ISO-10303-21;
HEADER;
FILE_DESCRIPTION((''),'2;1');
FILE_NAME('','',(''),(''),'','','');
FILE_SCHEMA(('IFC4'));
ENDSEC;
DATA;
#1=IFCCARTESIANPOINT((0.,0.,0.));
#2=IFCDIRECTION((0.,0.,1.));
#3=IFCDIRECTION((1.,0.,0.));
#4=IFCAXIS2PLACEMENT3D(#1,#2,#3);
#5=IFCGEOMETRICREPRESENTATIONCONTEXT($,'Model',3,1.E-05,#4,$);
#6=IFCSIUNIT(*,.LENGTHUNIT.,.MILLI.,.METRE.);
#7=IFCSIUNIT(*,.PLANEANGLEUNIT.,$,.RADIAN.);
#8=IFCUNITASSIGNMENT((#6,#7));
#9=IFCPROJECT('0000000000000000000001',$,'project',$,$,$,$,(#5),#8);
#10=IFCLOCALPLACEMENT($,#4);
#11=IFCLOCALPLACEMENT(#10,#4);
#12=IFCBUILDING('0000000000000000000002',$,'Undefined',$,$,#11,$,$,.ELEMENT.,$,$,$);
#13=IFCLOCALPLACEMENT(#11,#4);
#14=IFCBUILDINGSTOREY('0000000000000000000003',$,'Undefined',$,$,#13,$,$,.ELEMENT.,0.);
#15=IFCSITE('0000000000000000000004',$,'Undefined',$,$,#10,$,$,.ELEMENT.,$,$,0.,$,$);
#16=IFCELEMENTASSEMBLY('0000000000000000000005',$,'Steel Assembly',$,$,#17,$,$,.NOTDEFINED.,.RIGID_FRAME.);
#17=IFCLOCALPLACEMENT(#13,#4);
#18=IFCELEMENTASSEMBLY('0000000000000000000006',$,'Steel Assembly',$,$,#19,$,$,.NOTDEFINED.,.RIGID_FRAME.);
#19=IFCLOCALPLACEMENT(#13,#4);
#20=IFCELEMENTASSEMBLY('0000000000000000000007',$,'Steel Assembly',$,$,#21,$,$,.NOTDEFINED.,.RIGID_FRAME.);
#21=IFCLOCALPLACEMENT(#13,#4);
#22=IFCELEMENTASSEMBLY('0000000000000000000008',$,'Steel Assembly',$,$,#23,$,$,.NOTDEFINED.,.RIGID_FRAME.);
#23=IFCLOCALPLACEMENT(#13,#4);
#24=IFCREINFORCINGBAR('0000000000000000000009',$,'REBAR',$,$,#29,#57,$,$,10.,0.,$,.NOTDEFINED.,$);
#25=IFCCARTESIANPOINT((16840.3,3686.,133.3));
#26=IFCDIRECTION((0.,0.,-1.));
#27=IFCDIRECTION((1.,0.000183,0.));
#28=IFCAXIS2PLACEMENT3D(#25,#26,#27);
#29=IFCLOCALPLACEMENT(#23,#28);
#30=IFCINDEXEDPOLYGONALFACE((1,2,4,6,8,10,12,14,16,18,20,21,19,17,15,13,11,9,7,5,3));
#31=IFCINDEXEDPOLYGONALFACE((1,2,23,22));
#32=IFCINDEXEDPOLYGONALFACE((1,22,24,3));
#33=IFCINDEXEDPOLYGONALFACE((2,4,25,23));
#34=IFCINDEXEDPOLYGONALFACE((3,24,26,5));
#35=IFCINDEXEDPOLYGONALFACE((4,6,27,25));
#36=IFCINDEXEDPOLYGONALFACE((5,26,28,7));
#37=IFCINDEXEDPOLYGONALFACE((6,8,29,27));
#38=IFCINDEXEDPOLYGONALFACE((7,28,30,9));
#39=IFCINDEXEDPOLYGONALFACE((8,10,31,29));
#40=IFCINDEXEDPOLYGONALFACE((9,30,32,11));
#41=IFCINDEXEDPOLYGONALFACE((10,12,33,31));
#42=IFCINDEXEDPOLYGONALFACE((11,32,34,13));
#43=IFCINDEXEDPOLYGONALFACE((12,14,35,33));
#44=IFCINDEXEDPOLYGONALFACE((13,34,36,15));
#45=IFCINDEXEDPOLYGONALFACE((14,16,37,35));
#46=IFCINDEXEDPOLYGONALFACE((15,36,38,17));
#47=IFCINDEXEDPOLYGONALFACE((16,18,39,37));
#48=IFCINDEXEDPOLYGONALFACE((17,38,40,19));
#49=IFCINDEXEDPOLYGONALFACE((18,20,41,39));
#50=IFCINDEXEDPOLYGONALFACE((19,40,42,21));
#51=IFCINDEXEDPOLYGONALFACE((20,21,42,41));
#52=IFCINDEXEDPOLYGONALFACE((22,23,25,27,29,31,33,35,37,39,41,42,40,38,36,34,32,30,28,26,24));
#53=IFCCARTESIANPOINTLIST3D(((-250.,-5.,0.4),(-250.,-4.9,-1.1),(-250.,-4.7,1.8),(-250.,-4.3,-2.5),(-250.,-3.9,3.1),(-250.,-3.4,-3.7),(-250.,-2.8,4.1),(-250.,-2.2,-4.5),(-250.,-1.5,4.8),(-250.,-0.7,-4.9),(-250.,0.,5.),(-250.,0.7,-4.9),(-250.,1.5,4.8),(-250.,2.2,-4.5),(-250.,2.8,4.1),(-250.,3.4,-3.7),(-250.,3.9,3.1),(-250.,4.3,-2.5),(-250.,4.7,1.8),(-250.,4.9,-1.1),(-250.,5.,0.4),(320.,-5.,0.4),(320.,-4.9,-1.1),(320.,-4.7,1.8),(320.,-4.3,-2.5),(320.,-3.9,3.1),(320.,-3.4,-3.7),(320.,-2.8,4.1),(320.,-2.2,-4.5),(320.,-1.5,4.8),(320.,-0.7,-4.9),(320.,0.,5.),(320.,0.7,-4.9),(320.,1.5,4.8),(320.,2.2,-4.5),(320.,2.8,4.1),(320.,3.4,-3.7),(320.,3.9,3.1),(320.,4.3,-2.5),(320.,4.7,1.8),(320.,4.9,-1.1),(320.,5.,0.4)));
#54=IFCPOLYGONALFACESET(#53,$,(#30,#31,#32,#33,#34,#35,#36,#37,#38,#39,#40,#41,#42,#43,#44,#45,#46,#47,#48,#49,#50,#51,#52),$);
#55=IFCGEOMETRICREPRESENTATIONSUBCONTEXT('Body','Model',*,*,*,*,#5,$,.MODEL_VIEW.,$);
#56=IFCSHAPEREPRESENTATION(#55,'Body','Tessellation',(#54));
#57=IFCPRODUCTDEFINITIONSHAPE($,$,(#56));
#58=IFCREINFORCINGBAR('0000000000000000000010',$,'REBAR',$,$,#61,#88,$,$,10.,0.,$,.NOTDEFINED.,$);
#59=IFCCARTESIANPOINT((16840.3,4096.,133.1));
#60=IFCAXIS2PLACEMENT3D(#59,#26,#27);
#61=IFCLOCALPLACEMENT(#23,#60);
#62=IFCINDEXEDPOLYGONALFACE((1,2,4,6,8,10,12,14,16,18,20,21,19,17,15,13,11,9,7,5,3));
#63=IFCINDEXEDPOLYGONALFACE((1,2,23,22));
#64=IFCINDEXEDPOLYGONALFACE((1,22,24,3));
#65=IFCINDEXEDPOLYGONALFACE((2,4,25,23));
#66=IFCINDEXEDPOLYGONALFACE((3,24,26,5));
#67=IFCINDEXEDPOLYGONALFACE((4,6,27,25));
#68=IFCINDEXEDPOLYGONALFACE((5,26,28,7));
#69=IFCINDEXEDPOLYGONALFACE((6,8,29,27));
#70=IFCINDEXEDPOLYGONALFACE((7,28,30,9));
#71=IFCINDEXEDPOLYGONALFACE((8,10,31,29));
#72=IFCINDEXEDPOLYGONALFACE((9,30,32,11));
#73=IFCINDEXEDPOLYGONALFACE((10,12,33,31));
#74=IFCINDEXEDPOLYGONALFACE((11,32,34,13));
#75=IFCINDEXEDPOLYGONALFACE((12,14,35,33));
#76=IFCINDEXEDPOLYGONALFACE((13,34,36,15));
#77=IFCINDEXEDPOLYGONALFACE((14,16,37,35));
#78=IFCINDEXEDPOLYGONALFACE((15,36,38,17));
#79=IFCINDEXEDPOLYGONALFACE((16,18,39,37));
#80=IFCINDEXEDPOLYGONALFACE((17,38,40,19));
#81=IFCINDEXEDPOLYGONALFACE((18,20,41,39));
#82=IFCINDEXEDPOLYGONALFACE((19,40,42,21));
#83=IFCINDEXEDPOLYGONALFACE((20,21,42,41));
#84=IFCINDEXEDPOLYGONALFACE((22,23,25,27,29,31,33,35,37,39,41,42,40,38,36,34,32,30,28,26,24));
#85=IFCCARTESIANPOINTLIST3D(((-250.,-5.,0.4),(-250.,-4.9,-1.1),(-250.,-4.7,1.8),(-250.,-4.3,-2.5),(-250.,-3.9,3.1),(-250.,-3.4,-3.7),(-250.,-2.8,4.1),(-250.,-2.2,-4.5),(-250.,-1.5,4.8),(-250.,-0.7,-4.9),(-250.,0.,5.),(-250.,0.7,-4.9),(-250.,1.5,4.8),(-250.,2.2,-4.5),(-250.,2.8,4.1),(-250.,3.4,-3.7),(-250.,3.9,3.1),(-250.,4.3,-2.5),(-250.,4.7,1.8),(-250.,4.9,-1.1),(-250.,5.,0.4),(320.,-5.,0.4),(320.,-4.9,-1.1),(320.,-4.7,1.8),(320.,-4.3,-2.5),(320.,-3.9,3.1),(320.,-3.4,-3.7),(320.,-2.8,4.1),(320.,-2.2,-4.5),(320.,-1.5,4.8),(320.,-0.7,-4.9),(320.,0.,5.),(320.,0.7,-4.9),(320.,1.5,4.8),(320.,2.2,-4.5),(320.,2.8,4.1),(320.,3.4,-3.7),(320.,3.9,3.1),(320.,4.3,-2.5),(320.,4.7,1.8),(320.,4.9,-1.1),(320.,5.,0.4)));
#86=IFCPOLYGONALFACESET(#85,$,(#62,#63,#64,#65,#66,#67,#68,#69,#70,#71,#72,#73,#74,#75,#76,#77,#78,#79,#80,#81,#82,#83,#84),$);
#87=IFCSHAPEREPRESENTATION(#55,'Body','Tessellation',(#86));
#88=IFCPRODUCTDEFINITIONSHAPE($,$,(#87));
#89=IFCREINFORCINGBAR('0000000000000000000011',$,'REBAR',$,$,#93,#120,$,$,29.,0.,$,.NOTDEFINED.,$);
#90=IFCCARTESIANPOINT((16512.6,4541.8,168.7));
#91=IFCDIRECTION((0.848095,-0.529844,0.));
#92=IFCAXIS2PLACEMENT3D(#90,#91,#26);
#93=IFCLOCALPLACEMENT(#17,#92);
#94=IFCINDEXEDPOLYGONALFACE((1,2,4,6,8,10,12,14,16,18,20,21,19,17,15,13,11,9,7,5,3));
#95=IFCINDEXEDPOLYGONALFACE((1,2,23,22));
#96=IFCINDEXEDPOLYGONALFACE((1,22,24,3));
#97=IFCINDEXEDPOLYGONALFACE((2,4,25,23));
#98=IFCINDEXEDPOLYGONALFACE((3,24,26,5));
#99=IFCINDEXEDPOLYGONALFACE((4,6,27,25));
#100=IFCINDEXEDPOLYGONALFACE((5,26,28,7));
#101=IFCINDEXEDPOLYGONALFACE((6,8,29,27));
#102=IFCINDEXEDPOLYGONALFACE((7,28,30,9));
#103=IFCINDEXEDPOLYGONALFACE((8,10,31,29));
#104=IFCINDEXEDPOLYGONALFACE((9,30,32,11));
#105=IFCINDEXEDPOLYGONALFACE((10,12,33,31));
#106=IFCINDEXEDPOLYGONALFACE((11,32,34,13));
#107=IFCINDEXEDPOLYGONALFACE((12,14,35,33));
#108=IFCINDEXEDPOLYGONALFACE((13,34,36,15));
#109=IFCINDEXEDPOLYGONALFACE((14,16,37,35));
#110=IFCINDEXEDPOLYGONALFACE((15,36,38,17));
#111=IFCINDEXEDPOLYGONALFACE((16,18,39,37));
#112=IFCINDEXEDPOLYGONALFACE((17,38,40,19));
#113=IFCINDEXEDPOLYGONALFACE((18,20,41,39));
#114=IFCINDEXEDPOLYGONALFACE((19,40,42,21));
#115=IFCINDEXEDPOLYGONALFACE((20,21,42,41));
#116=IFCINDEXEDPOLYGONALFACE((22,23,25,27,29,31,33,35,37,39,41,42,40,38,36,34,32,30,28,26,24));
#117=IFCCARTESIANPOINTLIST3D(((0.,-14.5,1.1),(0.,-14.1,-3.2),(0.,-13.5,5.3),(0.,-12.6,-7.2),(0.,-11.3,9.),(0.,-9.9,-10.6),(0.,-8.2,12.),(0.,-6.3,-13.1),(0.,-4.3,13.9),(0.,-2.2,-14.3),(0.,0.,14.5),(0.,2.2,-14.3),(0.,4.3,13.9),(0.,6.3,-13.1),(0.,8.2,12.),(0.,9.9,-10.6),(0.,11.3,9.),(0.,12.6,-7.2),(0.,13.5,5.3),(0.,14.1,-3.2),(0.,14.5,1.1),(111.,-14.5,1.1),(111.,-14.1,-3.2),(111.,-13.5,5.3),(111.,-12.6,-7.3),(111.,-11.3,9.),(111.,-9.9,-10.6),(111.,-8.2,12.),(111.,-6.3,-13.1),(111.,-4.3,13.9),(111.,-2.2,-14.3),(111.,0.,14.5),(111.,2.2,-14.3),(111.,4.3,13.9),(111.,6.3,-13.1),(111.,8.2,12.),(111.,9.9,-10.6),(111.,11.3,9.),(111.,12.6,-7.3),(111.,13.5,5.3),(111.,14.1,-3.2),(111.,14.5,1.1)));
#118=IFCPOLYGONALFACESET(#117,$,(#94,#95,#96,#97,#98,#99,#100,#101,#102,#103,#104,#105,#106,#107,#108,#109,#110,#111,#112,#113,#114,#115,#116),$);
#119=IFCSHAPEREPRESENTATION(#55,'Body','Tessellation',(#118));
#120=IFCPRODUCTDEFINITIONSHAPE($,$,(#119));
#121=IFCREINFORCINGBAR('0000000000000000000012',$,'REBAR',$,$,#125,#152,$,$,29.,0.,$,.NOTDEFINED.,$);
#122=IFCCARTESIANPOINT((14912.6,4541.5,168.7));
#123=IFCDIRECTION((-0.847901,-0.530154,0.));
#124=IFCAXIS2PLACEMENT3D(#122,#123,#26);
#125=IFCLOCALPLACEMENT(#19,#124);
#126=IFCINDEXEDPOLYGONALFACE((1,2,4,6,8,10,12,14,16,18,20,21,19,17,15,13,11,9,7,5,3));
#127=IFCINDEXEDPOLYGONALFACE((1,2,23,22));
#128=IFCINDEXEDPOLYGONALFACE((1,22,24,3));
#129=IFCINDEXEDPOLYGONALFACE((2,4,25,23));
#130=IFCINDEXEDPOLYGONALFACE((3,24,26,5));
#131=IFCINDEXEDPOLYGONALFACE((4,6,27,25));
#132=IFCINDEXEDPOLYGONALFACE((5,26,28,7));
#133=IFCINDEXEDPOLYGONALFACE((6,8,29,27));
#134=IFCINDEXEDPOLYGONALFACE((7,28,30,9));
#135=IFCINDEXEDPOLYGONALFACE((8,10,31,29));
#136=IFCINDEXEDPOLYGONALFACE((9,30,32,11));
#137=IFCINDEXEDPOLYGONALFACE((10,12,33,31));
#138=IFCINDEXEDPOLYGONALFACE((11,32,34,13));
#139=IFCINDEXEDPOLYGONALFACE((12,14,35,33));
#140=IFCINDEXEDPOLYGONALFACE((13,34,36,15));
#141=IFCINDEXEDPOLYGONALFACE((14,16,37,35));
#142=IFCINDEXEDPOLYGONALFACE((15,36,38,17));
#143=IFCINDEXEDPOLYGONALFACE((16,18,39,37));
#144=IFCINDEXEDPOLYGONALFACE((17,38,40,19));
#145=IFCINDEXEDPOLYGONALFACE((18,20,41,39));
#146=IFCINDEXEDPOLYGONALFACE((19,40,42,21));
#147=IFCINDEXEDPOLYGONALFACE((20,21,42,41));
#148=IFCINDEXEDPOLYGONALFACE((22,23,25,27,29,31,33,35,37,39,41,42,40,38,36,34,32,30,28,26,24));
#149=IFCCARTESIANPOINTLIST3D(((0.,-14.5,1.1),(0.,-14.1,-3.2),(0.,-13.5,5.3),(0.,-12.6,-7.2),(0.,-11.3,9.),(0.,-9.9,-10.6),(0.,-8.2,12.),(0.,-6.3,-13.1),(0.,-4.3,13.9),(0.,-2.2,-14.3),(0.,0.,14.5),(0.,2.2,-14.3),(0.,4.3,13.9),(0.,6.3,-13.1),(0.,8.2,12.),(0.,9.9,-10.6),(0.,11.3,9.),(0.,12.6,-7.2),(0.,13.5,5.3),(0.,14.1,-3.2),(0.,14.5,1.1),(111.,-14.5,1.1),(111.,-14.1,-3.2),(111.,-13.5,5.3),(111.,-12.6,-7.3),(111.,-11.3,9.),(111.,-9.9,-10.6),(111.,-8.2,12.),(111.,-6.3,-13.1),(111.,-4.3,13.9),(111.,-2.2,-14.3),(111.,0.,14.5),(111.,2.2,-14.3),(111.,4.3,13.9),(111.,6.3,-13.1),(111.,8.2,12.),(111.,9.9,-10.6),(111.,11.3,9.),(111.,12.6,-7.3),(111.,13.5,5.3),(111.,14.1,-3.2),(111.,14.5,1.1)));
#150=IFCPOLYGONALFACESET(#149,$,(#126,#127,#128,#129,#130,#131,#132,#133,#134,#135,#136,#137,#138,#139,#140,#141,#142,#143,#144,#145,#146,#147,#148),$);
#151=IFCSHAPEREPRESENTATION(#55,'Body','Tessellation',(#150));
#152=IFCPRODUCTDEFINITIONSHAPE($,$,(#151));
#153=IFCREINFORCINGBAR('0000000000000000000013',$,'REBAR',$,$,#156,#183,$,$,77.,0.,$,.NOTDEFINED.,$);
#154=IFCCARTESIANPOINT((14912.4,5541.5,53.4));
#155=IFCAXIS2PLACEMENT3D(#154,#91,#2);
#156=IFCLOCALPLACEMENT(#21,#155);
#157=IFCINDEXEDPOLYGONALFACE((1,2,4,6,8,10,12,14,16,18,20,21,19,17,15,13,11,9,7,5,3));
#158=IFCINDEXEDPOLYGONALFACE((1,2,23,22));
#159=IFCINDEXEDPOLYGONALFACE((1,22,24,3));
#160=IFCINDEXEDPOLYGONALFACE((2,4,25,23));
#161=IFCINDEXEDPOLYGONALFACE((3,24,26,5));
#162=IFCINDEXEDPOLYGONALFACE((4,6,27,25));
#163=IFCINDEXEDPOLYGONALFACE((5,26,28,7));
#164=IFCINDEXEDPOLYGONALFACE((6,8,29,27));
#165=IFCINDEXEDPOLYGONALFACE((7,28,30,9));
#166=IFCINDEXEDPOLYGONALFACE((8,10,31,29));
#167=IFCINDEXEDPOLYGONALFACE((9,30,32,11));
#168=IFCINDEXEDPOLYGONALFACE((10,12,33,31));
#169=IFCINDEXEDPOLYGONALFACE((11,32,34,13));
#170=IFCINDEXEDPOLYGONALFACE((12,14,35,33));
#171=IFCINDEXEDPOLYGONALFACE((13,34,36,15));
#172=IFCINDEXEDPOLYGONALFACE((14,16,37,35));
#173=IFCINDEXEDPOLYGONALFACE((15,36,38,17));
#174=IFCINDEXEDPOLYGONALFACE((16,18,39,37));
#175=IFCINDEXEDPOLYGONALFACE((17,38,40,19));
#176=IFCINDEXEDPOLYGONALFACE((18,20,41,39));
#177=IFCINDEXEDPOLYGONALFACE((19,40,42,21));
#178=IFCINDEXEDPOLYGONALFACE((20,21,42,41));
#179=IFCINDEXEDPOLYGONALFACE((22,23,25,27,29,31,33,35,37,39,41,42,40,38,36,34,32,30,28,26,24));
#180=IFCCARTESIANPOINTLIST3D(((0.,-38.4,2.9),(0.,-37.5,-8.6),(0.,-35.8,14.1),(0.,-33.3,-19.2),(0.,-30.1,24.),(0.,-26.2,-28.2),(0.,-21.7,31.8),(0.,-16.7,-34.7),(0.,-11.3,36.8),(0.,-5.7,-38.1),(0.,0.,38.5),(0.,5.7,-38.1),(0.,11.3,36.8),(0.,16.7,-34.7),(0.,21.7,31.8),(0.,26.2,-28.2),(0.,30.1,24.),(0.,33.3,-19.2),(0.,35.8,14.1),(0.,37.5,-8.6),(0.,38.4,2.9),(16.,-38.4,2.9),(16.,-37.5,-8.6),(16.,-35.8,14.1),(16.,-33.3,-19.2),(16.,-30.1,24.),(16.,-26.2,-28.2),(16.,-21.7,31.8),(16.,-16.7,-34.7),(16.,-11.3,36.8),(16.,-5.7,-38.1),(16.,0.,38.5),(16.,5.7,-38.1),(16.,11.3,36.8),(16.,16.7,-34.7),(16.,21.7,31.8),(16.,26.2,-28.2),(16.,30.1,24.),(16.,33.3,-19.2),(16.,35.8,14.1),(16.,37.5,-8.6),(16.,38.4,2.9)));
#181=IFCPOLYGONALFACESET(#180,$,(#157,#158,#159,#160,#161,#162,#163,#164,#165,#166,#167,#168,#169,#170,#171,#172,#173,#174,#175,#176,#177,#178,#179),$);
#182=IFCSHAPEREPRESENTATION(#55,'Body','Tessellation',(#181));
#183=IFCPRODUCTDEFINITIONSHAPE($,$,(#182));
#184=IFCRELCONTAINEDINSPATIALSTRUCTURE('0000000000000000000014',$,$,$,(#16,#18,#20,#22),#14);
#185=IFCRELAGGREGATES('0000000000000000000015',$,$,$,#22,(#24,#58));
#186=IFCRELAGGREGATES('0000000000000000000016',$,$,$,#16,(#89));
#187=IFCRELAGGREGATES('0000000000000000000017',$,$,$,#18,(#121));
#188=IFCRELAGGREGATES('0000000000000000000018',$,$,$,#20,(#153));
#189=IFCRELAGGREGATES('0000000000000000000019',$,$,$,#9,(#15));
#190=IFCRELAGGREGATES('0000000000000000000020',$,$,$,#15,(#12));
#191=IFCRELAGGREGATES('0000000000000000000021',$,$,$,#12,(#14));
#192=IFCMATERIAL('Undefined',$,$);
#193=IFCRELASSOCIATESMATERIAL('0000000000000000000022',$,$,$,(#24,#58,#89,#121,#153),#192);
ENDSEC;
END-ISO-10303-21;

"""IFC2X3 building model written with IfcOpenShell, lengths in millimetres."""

from ifc_helpers import new_model, entity, si_unit, frame, origin_with_axes, place, context, subcontext, project, spatial, source, transform, mapped, material, element, aggregate, save


model = new_model("IFC2X3")

# Units and contexts
model_context = context("Model", 3, precision=1e-05, world=origin_with_axes())
body_context = subcontext(model_context, "Body", "Model", "MODEL_VIEW")
ifc_project = project(units=[si_unit("LENGTHUNIT", "METRE", prefix="MILLI"), si_unit("PLANEANGLEUNIT", "RADIAN")], contexts=[model_context])

# Site, building, storey
site_placement = place(None, origin_with_axes())
site = spatial("IfcSite", under=ifc_project, at=site_placement, Name="Undefined", CompositionType="ELEMENT", RefElevation=0.0)
building_placement = place(site_placement, origin_with_axes())
building = spatial("IfcBuilding", under=site, at=building_placement, Name="Undefined", CompositionType="ELEMENT")
storey_placement = place(building_placement, origin_with_axes())
storey = spatial("IfcBuildingStorey", under=building, at=storey_placement, Name="Undefined", CompositionType="ELEMENT", Elevation=0.0)

# Element assemblies
assembly_1_placement = place(storey_placement, origin_with_axes())
assembly_1 = element("IfcElementAssembly", 1, at=assembly_1_placement, inside=storey, Name="Steel Assembly", AssemblyPlace="NOTDEFINED", PredefinedType="RIGID_FRAME")
assembly_2_placement = place(storey_placement, origin_with_axes())
assembly_2 = element("IfcElementAssembly", 2, at=assembly_2_placement, inside=storey, Name="Steel Assembly", AssemblyPlace="NOTDEFINED", PredefinedType="RIGID_FRAME")
assembly_3_placement = place(storey_placement, origin_with_axes())
assembly_3 = element("IfcElementAssembly", 3, at=assembly_3_placement, inside=storey, Name="Steel Assembly", AssemblyPlace="NOTDEFINED", PredefinedType="RIGID_FRAME")

# Element assembly
assembly_4_placement = place(storey_placement, origin_with_axes())
assembly_4 = element("IfcElementAssembly", 4, at=assembly_4_placement, inside=storey, Name="Steel Assembly", AssemblyPlace="NOTDEFINED", PredefinedType="RIGID_FRAME")

# Shared definitions
ifc_material_1 = material(Name="Undefined")

# Reinforcing bars
shared_shape_1 = source(origin_with_axes(), body_context, "Body", "AdvancedSweptSolid", [
    entity("IfcSweptDiskSolid", entity("IfcTrimmedCurve", entity("IfcLine", entity("IfcCartesianPoint", [0.0, 0.0, 0.0]), entity("IfcVector", entity("IfcDirection", [1.0, 0.0, 0.0]), 1.0)), [entity("IfcParameterValue", 0.0)], [entity("IfcParameterValue", 570.0)], True, "PARAMETER"), 5.0, None, 0.0, 570.0),
])
reinforcing_bar_1_placement = place(assembly_4_placement, frame((16840.3, 3686.0, 133.3), z_axis=(0.0, 0.0, -1.0), x_axis=(1.0, 0.000183, 0.0)))
reinforcing_bar_1 = element("IfcReinforcingBar", 5, at=reinforcing_bar_1_placement, material=ifc_material_1, Name="REBAR", BarRole="NOTDEFINED", CrossSectionArea=0.0, NominalDiameter=10.0, context=body_context, shape_type="MappedRepresentation", body=[
    mapped(shared_shape_1, transform((-250.0, 0.0, 0.0))),
])
shared_shape_2 = source(origin_with_axes(), body_context, "Body", "AdvancedSweptSolid", [
    entity("IfcSweptDiskSolid", entity("IfcTrimmedCurve", entity("IfcLine", entity("IfcCartesianPoint", [0.0, 0.0, 0.0]), entity("IfcVector", entity("IfcDirection", [1.0, 0.0, 0.0]), 1.0)), [entity("IfcParameterValue", 0.0)], [entity("IfcParameterValue", 570.0)], True, "PARAMETER"), 5.0, None, 0.0, 570.0),
])
reinforcing_bar_2_placement = place(assembly_4_placement, frame((16840.3, 4096.0, 133.1), z_axis=(0.0, 0.0, -1.0), x_axis=(1.0, 0.000183, 0.0)))
reinforcing_bar_2 = element("IfcReinforcingBar", 6, at=reinforcing_bar_2_placement, material=ifc_material_1, Name="REBAR", BarRole="NOTDEFINED", CrossSectionArea=0.0, NominalDiameter=10.0, context=body_context, shape_type="MappedRepresentation", body=[
    mapped(shared_shape_2, transform((-250.0, 0.0, 0.0))),
])
aggregate(assembly_4, [reinforcing_bar_1, reinforcing_bar_2])
shared_shape_3 = source(origin_with_axes(), body_context, "Body", "AdvancedSweptSolid", [
    entity("IfcSweptDiskSolid", entity("IfcTrimmedCurve", entity("IfcLine", entity("IfcCartesianPoint", [0.0, 0.0, 0.0]), entity("IfcVector", entity("IfcDirection", [1.0, 0.0, 0.0]), 1.0)), [entity("IfcParameterValue", 0.0)], [entity("IfcParameterValue", 111.0)], True, "PARAMETER"), 14.5, None, 0.0, 111.0),
])
reinforcing_bar_3_placement = place(assembly_1_placement, frame((16512.6, 4541.8, 168.7), z_axis=(0.848095, -0.529844, 0.0), x_axis=(0.0, 0.0, -1.0)))
reinforcing_bar_3 = element("IfcReinforcingBar", 7, at=reinforcing_bar_3_placement, material=ifc_material_1, Name="REBAR", BarRole="NOTDEFINED", CrossSectionArea=0.0, NominalDiameter=29.0, context=body_context, shape_type="MappedRepresentation", body=[
    mapped(shared_shape_3, transform((0.0, 0.0, 0.0))),
])
aggregate(assembly_1, [reinforcing_bar_3])
shared_shape_4 = source(origin_with_axes(), body_context, "Body", "AdvancedSweptSolid", [
    entity("IfcSweptDiskSolid", entity("IfcTrimmedCurve", entity("IfcLine", entity("IfcCartesianPoint", [0.0, 0.0, 0.0]), entity("IfcVector", entity("IfcDirection", [1.0, 0.0, 0.0]), 1.0)), [entity("IfcParameterValue", 0.0)], [entity("IfcParameterValue", 111.0)], True, "PARAMETER"), 14.5, None, 0.0, 111.0),
])
reinforcing_bar_4_placement = place(assembly_2_placement, frame((14912.6, 4541.5, 168.7), z_axis=(-0.847901, -0.530154, 0.0), x_axis=(0.0, 0.0, -1.0)))
reinforcing_bar_4 = element("IfcReinforcingBar", 8, at=reinforcing_bar_4_placement, material=ifc_material_1, Name="REBAR", BarRole="NOTDEFINED", CrossSectionArea=0.0, NominalDiameter=29.0, context=body_context, shape_type="MappedRepresentation", body=[
    mapped(shared_shape_4, transform((0.0, 0.0, 0.0))),
])
aggregate(assembly_2, [reinforcing_bar_4])
shared_shape_5 = source(origin_with_axes(), body_context, "Body", "AdvancedSweptSolid", [
    entity("IfcSweptDiskSolid", entity("IfcTrimmedCurve", entity("IfcLine", entity("IfcCartesianPoint", [0.0, 0.0, 0.0]), entity("IfcVector", entity("IfcDirection", [1.0, 0.0, 0.0]), 1.0)), [entity("IfcParameterValue", 0.0)], [entity("IfcParameterValue", 16.0)], True, "PARAMETER"), 38.5, None, 0.0, 16.0),
])
reinforcing_bar_5_placement = place(assembly_3_placement, frame((14912.4, 5541.5, 53.4), z_axis=(0.848095, -0.529844, 0.0), x_axis=(0.0, 0.0, 1.0)))
reinforcing_bar_5 = element("IfcReinforcingBar", 9, at=reinforcing_bar_5_placement, material=ifc_material_1, Name="REBAR", BarRole="NOTDEFINED", CrossSectionArea=0.0, NominalDiameter=77.0, context=body_context, shape_type="MappedRepresentation", body=[
    mapped(shared_shape_5, transform((0.0, 0.0, 0.0))),
])
aggregate(assembly_3, [reinforcing_bar_5])

save(model, "model.ifc")
